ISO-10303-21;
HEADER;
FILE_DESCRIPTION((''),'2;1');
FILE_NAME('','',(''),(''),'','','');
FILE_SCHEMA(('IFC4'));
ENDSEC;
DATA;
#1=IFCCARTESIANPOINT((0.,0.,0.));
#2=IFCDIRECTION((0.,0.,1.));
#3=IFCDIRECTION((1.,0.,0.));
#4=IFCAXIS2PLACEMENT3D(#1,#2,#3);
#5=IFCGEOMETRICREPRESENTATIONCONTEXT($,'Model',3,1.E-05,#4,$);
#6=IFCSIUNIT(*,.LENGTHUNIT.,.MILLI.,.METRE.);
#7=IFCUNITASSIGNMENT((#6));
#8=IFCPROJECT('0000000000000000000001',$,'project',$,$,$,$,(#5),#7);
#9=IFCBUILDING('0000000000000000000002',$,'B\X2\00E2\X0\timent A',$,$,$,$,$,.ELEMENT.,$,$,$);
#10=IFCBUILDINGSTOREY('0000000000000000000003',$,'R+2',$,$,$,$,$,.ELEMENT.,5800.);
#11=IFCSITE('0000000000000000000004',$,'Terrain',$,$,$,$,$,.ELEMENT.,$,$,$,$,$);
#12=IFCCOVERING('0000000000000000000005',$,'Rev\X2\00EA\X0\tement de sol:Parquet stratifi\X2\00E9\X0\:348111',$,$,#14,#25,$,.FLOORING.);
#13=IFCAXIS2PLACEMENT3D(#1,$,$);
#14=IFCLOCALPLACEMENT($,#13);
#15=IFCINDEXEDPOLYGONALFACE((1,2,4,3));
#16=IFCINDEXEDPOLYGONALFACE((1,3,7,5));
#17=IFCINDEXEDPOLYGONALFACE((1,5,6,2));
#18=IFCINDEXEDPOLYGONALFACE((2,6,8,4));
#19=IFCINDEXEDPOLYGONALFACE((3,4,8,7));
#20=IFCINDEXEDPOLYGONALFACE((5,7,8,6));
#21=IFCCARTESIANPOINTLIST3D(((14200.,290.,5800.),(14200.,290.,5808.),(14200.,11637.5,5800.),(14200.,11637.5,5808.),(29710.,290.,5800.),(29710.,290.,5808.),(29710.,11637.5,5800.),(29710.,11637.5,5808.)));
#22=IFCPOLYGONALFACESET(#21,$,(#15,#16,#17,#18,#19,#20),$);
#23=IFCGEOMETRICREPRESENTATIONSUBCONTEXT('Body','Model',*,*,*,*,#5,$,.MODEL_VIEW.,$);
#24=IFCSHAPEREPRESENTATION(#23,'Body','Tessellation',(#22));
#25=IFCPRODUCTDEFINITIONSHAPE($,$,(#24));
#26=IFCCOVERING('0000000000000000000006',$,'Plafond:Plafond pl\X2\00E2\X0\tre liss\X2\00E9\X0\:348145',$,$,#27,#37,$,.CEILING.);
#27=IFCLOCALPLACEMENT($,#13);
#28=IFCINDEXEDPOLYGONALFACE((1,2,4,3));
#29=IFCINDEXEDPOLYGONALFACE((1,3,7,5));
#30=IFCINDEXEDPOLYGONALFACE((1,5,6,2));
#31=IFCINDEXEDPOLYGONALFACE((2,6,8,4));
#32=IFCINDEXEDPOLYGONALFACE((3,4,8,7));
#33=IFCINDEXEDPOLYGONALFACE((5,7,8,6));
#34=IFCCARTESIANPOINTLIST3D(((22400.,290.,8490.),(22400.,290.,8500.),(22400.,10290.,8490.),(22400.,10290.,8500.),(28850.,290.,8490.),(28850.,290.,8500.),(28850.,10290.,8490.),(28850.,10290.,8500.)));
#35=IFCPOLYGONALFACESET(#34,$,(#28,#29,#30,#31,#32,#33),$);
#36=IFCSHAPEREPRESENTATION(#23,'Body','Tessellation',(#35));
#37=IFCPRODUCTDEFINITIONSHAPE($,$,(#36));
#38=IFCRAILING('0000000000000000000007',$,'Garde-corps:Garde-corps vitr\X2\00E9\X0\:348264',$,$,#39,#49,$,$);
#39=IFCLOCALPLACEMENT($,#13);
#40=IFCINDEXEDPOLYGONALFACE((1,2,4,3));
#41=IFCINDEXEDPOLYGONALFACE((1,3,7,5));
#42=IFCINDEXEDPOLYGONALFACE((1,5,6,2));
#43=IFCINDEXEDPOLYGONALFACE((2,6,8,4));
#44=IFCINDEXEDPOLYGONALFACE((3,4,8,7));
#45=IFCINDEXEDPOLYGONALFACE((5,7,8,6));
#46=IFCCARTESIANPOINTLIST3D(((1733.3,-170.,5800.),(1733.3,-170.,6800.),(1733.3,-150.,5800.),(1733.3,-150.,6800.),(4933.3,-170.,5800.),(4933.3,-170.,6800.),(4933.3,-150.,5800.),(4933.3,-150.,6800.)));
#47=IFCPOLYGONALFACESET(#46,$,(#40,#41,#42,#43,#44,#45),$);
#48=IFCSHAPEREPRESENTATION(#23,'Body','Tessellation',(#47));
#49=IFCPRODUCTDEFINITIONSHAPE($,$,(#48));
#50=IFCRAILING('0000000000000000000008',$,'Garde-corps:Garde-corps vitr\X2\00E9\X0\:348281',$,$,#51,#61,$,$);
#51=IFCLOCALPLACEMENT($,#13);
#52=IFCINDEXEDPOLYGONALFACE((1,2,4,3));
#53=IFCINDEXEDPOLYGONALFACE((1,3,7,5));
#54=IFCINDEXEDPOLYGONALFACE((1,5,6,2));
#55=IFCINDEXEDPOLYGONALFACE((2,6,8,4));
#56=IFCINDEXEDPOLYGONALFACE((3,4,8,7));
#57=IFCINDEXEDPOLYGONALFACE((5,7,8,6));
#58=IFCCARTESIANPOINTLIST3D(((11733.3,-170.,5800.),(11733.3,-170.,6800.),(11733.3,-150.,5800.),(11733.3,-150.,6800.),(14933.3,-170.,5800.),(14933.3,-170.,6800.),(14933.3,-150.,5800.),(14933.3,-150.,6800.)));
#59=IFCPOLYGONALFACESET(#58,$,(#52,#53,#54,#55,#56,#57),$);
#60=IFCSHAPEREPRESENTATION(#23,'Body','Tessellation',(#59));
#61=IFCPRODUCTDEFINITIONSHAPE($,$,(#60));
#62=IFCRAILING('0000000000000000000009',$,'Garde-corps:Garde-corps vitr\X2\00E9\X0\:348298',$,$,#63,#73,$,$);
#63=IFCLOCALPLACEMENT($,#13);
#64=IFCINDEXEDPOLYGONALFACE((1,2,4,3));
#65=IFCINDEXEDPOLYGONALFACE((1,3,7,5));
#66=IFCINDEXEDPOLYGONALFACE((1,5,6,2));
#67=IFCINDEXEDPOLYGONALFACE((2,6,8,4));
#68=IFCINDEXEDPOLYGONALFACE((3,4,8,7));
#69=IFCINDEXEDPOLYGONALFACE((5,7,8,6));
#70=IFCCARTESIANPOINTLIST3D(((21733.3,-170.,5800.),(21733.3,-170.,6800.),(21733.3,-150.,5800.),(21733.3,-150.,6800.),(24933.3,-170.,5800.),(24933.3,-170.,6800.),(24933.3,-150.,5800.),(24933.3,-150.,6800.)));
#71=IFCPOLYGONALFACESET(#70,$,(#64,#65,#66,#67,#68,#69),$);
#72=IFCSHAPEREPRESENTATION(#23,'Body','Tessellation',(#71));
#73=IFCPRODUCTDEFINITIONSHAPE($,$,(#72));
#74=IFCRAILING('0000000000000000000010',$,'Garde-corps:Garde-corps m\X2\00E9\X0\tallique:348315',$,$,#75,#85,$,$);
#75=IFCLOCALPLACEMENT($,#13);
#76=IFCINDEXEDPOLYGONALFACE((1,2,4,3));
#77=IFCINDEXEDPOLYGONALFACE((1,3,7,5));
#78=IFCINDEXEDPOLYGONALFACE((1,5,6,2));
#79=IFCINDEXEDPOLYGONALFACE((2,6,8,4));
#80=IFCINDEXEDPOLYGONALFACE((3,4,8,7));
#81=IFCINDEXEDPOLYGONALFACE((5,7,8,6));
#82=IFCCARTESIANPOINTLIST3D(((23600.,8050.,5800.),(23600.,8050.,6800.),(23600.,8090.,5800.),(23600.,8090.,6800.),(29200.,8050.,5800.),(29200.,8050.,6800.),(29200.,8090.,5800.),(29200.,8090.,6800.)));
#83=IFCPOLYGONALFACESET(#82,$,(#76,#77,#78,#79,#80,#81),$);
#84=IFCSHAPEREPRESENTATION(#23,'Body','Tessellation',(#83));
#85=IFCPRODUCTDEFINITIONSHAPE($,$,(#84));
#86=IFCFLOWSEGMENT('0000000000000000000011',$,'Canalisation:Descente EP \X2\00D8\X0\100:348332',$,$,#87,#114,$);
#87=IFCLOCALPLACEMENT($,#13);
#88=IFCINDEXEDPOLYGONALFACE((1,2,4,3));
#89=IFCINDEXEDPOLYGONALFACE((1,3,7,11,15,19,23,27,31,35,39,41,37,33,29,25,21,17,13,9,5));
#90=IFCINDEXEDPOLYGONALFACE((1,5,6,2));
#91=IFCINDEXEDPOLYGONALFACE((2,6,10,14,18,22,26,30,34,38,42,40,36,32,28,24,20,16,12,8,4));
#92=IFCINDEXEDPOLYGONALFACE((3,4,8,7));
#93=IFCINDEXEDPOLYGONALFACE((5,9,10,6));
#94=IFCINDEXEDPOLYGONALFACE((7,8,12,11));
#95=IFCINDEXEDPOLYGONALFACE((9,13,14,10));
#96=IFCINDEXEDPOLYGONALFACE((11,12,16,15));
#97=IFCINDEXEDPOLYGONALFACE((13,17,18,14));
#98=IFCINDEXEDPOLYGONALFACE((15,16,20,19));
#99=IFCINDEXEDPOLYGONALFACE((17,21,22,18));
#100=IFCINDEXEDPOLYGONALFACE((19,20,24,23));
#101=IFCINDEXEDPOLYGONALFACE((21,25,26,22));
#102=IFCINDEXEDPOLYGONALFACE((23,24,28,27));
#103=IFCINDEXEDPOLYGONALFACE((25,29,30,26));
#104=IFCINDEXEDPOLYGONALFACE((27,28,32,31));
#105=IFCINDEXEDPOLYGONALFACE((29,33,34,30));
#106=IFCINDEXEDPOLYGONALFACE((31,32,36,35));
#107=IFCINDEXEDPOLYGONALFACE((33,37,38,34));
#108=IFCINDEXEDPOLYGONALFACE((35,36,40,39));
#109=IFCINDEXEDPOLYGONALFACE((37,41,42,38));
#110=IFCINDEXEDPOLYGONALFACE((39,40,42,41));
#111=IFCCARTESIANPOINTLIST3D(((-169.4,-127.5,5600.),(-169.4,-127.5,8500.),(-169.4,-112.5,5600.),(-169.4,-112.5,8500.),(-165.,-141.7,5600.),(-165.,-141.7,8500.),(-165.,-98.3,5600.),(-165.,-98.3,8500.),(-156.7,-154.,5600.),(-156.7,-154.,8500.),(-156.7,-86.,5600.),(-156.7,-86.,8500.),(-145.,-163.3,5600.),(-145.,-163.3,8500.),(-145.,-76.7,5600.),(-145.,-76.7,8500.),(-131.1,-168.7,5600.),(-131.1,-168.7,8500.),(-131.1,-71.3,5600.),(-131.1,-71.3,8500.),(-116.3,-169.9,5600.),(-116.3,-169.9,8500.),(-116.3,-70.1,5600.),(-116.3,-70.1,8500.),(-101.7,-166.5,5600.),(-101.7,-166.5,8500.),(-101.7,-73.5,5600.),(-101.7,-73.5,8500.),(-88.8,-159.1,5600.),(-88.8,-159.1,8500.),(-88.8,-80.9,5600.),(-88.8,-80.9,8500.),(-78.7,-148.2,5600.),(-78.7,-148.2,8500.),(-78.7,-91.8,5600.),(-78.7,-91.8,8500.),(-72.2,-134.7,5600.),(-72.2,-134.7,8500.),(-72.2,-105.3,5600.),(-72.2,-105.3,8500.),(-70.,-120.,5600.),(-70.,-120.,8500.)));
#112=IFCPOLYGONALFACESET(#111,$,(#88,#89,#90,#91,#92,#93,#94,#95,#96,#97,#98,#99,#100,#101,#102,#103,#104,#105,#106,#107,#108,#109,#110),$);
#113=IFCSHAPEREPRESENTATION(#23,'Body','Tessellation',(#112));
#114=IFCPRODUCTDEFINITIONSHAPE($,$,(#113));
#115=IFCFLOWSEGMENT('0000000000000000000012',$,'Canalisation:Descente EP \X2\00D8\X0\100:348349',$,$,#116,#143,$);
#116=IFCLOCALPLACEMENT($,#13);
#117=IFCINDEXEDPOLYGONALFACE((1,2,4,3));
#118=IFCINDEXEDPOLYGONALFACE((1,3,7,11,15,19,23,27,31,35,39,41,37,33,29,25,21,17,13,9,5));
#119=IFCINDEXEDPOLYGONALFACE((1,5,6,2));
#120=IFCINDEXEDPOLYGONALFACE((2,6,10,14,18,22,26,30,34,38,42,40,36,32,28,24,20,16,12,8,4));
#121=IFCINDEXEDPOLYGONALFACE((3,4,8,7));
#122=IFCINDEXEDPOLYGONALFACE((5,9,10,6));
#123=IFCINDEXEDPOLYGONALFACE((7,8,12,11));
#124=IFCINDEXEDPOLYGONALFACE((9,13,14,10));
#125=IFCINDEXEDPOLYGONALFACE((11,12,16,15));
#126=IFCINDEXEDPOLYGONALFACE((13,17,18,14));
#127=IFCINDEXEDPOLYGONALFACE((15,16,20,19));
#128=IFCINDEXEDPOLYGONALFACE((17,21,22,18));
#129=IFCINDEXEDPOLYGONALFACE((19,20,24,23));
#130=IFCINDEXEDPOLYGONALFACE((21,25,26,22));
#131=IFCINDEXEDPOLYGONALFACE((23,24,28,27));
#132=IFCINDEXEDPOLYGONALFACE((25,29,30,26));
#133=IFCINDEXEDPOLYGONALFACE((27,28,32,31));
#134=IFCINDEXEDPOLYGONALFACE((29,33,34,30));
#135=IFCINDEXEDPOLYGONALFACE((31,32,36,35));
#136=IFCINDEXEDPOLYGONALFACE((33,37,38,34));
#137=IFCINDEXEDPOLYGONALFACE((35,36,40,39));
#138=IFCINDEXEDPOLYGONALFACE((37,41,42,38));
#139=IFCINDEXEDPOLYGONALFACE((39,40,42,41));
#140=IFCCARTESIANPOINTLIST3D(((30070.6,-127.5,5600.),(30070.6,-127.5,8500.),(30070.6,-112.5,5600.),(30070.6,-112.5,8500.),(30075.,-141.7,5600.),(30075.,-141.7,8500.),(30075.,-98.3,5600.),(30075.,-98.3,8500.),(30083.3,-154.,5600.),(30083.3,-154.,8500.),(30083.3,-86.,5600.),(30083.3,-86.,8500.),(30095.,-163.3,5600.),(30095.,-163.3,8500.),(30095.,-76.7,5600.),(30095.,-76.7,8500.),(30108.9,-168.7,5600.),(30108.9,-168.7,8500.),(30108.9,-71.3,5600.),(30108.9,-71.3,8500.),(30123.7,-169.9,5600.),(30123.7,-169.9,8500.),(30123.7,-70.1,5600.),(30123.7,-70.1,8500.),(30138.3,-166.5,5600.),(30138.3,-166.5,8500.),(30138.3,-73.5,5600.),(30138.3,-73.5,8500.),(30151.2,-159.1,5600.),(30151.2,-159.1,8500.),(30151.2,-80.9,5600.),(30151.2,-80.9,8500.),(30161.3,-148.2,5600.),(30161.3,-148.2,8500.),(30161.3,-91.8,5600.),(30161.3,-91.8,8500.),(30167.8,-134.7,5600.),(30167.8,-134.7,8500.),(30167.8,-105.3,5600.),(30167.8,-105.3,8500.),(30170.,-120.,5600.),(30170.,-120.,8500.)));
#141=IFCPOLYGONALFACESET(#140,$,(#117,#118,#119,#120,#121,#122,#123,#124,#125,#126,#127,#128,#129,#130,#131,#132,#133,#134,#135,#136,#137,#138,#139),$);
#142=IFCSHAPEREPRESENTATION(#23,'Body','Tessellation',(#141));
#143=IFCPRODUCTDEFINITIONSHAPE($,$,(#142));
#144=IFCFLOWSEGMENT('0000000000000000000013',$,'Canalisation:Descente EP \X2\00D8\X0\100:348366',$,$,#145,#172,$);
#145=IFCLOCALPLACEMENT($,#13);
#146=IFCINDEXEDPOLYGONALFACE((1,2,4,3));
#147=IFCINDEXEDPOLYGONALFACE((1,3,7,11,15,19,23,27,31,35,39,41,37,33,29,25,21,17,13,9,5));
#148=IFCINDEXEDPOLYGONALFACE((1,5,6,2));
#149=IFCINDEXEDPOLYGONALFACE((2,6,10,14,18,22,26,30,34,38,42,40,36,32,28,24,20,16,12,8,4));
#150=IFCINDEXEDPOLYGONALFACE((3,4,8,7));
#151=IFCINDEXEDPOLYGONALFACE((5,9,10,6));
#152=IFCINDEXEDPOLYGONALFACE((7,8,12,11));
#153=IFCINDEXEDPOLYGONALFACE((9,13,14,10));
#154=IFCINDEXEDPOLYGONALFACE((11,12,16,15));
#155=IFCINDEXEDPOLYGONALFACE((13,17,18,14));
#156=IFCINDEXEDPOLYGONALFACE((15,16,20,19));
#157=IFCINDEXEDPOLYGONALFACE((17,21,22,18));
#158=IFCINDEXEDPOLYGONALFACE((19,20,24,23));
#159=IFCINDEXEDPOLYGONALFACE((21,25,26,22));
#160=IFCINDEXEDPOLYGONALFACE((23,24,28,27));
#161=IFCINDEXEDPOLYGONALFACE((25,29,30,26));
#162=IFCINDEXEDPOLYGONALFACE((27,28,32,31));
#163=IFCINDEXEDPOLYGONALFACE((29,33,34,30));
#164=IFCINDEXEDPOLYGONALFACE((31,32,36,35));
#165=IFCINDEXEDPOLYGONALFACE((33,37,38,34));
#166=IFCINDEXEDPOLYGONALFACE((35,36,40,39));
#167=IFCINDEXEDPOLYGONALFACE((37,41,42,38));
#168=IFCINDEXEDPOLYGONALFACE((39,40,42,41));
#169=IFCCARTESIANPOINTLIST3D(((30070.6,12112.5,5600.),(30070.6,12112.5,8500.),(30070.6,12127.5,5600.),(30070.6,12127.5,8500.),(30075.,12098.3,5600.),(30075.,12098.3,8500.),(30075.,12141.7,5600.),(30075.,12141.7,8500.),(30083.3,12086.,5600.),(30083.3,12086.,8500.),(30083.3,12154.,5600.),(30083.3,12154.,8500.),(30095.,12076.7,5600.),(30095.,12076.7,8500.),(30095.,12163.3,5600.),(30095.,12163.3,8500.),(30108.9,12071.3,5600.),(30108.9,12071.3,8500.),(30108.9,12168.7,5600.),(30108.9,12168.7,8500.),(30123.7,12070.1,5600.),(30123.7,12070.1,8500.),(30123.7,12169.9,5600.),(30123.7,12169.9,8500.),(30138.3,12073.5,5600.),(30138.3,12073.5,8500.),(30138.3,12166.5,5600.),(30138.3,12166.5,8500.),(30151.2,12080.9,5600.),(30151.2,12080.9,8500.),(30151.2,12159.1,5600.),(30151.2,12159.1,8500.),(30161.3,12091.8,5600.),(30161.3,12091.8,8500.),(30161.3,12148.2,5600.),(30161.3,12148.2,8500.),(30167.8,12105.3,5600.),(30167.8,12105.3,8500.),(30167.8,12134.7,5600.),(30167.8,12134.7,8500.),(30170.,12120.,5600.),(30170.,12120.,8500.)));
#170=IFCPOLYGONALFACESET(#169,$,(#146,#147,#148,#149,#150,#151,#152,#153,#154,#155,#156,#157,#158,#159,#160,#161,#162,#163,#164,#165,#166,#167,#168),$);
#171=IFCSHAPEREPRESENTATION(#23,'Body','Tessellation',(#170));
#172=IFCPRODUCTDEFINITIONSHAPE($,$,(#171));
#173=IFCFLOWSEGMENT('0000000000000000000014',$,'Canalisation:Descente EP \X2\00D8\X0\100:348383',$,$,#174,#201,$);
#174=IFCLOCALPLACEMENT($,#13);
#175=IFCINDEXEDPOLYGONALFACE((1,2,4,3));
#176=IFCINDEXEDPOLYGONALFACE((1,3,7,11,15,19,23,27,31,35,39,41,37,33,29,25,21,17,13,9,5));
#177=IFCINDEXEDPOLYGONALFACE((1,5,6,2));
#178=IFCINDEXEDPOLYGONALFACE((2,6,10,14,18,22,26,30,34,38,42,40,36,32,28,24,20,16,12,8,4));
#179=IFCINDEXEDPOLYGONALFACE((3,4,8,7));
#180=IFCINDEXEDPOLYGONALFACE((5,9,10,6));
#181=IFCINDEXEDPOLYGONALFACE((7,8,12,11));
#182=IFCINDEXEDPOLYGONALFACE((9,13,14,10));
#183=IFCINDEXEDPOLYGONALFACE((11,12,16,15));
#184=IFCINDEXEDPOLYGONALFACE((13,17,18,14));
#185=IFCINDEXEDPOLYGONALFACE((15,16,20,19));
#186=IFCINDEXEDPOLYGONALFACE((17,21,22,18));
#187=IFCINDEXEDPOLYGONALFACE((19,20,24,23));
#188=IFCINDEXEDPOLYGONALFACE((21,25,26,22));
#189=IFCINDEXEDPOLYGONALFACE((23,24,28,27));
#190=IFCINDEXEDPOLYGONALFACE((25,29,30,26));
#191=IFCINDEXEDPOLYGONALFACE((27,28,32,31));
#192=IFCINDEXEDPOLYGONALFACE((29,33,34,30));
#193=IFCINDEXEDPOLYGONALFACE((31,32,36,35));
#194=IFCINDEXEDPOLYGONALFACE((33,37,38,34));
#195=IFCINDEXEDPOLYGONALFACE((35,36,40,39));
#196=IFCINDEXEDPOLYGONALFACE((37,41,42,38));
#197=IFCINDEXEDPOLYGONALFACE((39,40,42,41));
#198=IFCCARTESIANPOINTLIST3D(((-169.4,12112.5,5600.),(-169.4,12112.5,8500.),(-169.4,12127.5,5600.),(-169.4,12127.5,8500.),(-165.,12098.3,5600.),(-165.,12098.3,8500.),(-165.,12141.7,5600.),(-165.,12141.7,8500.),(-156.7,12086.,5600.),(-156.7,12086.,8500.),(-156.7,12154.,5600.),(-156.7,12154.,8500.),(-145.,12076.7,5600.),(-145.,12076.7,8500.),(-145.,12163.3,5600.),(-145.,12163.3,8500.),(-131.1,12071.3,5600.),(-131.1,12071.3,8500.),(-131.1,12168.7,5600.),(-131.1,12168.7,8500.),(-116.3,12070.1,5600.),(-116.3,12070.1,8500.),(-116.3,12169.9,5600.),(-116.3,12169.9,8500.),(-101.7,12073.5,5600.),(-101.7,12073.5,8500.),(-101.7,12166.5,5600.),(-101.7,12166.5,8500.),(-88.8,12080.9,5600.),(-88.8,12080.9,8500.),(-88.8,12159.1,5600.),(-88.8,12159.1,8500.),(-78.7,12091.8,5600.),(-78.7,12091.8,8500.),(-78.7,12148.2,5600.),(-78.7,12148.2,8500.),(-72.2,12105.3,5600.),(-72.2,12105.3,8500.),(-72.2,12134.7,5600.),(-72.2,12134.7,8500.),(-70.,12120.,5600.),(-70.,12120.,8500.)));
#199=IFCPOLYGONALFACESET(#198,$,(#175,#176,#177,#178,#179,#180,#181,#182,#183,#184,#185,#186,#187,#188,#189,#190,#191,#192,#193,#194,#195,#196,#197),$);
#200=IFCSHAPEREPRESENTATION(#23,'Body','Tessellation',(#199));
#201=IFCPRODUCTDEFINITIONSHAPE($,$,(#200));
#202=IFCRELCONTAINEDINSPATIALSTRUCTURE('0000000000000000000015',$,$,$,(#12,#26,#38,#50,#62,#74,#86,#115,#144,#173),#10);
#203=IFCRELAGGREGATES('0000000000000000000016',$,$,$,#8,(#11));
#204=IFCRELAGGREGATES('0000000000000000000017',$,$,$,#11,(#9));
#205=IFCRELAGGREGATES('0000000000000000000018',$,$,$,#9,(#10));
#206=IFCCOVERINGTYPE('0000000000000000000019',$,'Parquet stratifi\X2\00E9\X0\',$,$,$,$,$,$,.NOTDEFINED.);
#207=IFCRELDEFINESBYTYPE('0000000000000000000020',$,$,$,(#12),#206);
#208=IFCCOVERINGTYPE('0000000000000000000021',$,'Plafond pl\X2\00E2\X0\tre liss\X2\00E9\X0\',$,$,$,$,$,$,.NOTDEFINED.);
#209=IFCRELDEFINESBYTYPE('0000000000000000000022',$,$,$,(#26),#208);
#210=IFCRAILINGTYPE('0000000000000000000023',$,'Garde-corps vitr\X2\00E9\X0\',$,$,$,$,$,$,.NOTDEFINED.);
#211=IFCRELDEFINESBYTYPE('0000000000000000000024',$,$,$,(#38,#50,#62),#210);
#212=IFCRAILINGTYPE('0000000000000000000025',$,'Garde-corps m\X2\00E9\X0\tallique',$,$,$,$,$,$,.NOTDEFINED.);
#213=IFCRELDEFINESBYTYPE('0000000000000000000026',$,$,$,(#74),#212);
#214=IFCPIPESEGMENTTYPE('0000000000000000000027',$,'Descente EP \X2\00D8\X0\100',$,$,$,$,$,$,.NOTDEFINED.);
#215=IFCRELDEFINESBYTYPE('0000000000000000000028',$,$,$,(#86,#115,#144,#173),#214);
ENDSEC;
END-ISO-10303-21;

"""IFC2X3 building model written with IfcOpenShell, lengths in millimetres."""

from ifc_helpers import new_model, si_unit, frame, frame_2d, origin_with_axes, origin_2d, place, context, subcontext, project, spatial, rectangle, circle, extrude, type_object, element, save


model = new_model("IFC2X3")

# Units and contexts
model_context = context("Model", 3, precision=1e-05, world=origin_with_axes())
body_context = subcontext(model_context, "Body", "Model", "MODEL_VIEW")
ifc_project = project(units=[si_unit("LENGTHUNIT", "METRE", prefix="MILLI")], contexts=[model_context])

# Site, building, storey
site = spatial("IfcSite", under=ifc_project, Name="Terrain", CompositionType="ELEMENT")
building = spatial("IfcBuilding", under=site, Name="Bâtiment A", CompositionType="ELEMENT")
storey = spatial("IfcBuildingStorey", under=building, Name="R+2", CompositionType="ELEMENT", Elevation=5800.0)

# Coverings
covering_type_1 = type_object("IfcCoveringType", Name="Parquet stratifié", PredefinedType="NOTDEFINED")
covering_1_placement = place(None, origin_with_axes())
element("IfcCovering", 1, at=covering_1_placement, inside=storey, type_object=covering_type_1, Name="Revêtement de sol:Parquet stratifié:348111", PredefinedType="FLOORING", context=body_context, shape_type="SweptSolid", body=[
    extrude(rectangle(XDim=15510.0, YDim=11347.5, at=frame_2d((21955.0, 5963.8))), frame((0.0, 0.0, 5800.0), z_axis=(0.0, 0.0, 1.0), x_axis=(1.0, 0.0, 0.0)), (0.0, 0.0, 1.0), 8.0),
])
covering_type_2 = type_object("IfcCoveringType", Name="Plafond plâtre lissé", PredefinedType="NOTDEFINED")
covering_2_placement = place(None, origin_with_axes())
element("IfcCovering", 2, at=covering_2_placement, inside=storey, type_object=covering_type_2, Name="Plafond:Plafond plâtre lissé:348145", PredefinedType="CEILING", context=body_context, shape_type="SweptSolid", body=[
    extrude(rectangle(XDim=6450.0, YDim=10000.0, at=frame_2d((25625.0, 5290.0))), frame((0.0, 0.0, 8490.0), z_axis=(0.0, 0.0, 1.0), x_axis=(1.0, 0.0, 0.0)), (0.0, 0.0, 1.0), 10.0),
])

# Railings
railing_type_1 = type_object("IfcRailingType", Name="Garde-corps vitré", PredefinedType="NOTDEFINED")
railing_1_placement = place(None, origin_with_axes())
element("IfcRailing", 3, at=railing_1_placement, inside=storey, type_object=railing_type_1, Name="Garde-corps:Garde-corps vitré:348264", context=body_context, shape_type="SweptSolid", body=[
    extrude(rectangle(XDim=3200.0, YDim=20.0, at=frame_2d((3333.3, -160.0))), frame((0.0, 0.0, 5800.0), z_axis=(0.0, 0.0, 1.0), x_axis=(1.0, 0.0, 0.0)), (0.0, 0.0, 1.0), 1000.0),
])
railing_2_placement = place(None, origin_with_axes())
element("IfcRailing", 4, at=railing_2_placement, inside=storey, type_object=railing_type_1, Name="Garde-corps:Garde-corps vitré:348281", context=body_context, shape_type="SweptSolid", body=[
    extrude(rectangle(XDim=3200.0, YDim=20.0, at=frame_2d((13333.3, -160.0))), frame((0.0, 0.0, 5800.0), z_axis=(0.0, 0.0, 1.0), x_axis=(1.0, 0.0, 0.0)), (0.0, 0.0, 1.0), 1000.0),
])
railing_3_placement = place(None, origin_with_axes())
element("IfcRailing", 5, at=railing_3_placement, inside=storey, type_object=railing_type_1, Name="Garde-corps:Garde-corps vitré:348298", context=body_context, shape_type="SweptSolid", body=[
    extrude(rectangle(XDim=3200.0, YDim=20.0, at=frame_2d((23333.3, -160.0))), frame((0.0, 0.0, 5800.0), z_axis=(0.0, 0.0, 1.0), x_axis=(1.0, 0.0, 0.0)), (0.0, 0.0, 1.0), 1000.0),
])
railing_type_2 = type_object("IfcRailingType", Name="Garde-corps métallique", PredefinedType="NOTDEFINED")
railing_4_placement = place(None, origin_with_axes())
element("IfcRailing", 6, at=railing_4_placement, inside=storey, type_object=railing_type_2, Name="Garde-corps:Garde-corps métallique:348315", context=body_context, shape_type="SweptSolid", body=[
    extrude(rectangle(XDim=5600.0, YDim=40.0, at=frame_2d((26400.0, 8070.0))), frame((0.0, 0.0, 5800.0), z_axis=(0.0, 0.0, 1.0), x_axis=(1.0, 0.0, 0.0)), (0.0, 0.0, 1.0), 1000.0),
])

# Flow segments
pipe_segment_type = type_object("IfcPipeSegmentType", Name="Descente EP Ø100", PredefinedType="NOTDEFINED")
flow_segment_1_placement = place(None, origin_with_axes())
element("IfcFlowSegment", 7, at=flow_segment_1_placement, inside=storey, type_object=pipe_segment_type, Name="Canalisation:Descente EP Ø100:348332", context=body_context, shape_type="SweptSolid", body=[
    extrude(circle(Radius=50.0, at=origin_2d()), frame((-120.0, -120.0, 5600.0), z_axis=(0.0, 0.0, 1.0), x_axis=(1.0, 0.0, 0.0)), (0.0, 0.0, 1.0), 2900.0),
])
flow_segment_2_placement = place(None, origin_with_axes())
element("IfcFlowSegment", 8, at=flow_segment_2_placement, inside=storey, type_object=pipe_segment_type, Name="Canalisation:Descente EP Ø100:348349", context=body_context, shape_type="SweptSolid", body=[
    extrude(circle(Radius=50.0, at=origin_2d()), frame((30120.0, -120.0, 5600.0), z_axis=(0.0, 0.0, 1.0), x_axis=(1.0, 0.0, 0.0)), (0.0, 0.0, 1.0), 2900.0),
])
flow_segment_3_placement = place(None, origin_with_axes())
element("IfcFlowSegment", 9, at=flow_segment_3_placement, inside=storey, type_object=pipe_segment_type, Name="Canalisation:Descente EP Ø100:348366", context=body_context, shape_type="SweptSolid", body=[
    extrude(circle(Radius=50.0, at=origin_2d()), frame((30120.0, 12120.0, 5600.0), z_axis=(0.0, 0.0, 1.0), x_axis=(1.0, 0.0, 0.0)), (0.0, 0.0, 1.0), 2900.0),
])
flow_segment_4_placement = place(None, origin_with_axes())
element("IfcFlowSegment", 10, at=flow_segment_4_placement, inside=storey, type_object=pipe_segment_type, Name="Canalisation:Descente EP Ø100:348383", context=body_context, shape_type="SweptSolid", body=[
    extrude(circle(Radius=50.0, at=origin_2d()), frame((-120.0, 12120.0, 5600.0), z_axis=(0.0, 0.0, 1.0), x_axis=(1.0, 0.0, 0.0)), (0.0, 0.0, 1.0), 2900.0),
])

save(model, "model.ifc")
